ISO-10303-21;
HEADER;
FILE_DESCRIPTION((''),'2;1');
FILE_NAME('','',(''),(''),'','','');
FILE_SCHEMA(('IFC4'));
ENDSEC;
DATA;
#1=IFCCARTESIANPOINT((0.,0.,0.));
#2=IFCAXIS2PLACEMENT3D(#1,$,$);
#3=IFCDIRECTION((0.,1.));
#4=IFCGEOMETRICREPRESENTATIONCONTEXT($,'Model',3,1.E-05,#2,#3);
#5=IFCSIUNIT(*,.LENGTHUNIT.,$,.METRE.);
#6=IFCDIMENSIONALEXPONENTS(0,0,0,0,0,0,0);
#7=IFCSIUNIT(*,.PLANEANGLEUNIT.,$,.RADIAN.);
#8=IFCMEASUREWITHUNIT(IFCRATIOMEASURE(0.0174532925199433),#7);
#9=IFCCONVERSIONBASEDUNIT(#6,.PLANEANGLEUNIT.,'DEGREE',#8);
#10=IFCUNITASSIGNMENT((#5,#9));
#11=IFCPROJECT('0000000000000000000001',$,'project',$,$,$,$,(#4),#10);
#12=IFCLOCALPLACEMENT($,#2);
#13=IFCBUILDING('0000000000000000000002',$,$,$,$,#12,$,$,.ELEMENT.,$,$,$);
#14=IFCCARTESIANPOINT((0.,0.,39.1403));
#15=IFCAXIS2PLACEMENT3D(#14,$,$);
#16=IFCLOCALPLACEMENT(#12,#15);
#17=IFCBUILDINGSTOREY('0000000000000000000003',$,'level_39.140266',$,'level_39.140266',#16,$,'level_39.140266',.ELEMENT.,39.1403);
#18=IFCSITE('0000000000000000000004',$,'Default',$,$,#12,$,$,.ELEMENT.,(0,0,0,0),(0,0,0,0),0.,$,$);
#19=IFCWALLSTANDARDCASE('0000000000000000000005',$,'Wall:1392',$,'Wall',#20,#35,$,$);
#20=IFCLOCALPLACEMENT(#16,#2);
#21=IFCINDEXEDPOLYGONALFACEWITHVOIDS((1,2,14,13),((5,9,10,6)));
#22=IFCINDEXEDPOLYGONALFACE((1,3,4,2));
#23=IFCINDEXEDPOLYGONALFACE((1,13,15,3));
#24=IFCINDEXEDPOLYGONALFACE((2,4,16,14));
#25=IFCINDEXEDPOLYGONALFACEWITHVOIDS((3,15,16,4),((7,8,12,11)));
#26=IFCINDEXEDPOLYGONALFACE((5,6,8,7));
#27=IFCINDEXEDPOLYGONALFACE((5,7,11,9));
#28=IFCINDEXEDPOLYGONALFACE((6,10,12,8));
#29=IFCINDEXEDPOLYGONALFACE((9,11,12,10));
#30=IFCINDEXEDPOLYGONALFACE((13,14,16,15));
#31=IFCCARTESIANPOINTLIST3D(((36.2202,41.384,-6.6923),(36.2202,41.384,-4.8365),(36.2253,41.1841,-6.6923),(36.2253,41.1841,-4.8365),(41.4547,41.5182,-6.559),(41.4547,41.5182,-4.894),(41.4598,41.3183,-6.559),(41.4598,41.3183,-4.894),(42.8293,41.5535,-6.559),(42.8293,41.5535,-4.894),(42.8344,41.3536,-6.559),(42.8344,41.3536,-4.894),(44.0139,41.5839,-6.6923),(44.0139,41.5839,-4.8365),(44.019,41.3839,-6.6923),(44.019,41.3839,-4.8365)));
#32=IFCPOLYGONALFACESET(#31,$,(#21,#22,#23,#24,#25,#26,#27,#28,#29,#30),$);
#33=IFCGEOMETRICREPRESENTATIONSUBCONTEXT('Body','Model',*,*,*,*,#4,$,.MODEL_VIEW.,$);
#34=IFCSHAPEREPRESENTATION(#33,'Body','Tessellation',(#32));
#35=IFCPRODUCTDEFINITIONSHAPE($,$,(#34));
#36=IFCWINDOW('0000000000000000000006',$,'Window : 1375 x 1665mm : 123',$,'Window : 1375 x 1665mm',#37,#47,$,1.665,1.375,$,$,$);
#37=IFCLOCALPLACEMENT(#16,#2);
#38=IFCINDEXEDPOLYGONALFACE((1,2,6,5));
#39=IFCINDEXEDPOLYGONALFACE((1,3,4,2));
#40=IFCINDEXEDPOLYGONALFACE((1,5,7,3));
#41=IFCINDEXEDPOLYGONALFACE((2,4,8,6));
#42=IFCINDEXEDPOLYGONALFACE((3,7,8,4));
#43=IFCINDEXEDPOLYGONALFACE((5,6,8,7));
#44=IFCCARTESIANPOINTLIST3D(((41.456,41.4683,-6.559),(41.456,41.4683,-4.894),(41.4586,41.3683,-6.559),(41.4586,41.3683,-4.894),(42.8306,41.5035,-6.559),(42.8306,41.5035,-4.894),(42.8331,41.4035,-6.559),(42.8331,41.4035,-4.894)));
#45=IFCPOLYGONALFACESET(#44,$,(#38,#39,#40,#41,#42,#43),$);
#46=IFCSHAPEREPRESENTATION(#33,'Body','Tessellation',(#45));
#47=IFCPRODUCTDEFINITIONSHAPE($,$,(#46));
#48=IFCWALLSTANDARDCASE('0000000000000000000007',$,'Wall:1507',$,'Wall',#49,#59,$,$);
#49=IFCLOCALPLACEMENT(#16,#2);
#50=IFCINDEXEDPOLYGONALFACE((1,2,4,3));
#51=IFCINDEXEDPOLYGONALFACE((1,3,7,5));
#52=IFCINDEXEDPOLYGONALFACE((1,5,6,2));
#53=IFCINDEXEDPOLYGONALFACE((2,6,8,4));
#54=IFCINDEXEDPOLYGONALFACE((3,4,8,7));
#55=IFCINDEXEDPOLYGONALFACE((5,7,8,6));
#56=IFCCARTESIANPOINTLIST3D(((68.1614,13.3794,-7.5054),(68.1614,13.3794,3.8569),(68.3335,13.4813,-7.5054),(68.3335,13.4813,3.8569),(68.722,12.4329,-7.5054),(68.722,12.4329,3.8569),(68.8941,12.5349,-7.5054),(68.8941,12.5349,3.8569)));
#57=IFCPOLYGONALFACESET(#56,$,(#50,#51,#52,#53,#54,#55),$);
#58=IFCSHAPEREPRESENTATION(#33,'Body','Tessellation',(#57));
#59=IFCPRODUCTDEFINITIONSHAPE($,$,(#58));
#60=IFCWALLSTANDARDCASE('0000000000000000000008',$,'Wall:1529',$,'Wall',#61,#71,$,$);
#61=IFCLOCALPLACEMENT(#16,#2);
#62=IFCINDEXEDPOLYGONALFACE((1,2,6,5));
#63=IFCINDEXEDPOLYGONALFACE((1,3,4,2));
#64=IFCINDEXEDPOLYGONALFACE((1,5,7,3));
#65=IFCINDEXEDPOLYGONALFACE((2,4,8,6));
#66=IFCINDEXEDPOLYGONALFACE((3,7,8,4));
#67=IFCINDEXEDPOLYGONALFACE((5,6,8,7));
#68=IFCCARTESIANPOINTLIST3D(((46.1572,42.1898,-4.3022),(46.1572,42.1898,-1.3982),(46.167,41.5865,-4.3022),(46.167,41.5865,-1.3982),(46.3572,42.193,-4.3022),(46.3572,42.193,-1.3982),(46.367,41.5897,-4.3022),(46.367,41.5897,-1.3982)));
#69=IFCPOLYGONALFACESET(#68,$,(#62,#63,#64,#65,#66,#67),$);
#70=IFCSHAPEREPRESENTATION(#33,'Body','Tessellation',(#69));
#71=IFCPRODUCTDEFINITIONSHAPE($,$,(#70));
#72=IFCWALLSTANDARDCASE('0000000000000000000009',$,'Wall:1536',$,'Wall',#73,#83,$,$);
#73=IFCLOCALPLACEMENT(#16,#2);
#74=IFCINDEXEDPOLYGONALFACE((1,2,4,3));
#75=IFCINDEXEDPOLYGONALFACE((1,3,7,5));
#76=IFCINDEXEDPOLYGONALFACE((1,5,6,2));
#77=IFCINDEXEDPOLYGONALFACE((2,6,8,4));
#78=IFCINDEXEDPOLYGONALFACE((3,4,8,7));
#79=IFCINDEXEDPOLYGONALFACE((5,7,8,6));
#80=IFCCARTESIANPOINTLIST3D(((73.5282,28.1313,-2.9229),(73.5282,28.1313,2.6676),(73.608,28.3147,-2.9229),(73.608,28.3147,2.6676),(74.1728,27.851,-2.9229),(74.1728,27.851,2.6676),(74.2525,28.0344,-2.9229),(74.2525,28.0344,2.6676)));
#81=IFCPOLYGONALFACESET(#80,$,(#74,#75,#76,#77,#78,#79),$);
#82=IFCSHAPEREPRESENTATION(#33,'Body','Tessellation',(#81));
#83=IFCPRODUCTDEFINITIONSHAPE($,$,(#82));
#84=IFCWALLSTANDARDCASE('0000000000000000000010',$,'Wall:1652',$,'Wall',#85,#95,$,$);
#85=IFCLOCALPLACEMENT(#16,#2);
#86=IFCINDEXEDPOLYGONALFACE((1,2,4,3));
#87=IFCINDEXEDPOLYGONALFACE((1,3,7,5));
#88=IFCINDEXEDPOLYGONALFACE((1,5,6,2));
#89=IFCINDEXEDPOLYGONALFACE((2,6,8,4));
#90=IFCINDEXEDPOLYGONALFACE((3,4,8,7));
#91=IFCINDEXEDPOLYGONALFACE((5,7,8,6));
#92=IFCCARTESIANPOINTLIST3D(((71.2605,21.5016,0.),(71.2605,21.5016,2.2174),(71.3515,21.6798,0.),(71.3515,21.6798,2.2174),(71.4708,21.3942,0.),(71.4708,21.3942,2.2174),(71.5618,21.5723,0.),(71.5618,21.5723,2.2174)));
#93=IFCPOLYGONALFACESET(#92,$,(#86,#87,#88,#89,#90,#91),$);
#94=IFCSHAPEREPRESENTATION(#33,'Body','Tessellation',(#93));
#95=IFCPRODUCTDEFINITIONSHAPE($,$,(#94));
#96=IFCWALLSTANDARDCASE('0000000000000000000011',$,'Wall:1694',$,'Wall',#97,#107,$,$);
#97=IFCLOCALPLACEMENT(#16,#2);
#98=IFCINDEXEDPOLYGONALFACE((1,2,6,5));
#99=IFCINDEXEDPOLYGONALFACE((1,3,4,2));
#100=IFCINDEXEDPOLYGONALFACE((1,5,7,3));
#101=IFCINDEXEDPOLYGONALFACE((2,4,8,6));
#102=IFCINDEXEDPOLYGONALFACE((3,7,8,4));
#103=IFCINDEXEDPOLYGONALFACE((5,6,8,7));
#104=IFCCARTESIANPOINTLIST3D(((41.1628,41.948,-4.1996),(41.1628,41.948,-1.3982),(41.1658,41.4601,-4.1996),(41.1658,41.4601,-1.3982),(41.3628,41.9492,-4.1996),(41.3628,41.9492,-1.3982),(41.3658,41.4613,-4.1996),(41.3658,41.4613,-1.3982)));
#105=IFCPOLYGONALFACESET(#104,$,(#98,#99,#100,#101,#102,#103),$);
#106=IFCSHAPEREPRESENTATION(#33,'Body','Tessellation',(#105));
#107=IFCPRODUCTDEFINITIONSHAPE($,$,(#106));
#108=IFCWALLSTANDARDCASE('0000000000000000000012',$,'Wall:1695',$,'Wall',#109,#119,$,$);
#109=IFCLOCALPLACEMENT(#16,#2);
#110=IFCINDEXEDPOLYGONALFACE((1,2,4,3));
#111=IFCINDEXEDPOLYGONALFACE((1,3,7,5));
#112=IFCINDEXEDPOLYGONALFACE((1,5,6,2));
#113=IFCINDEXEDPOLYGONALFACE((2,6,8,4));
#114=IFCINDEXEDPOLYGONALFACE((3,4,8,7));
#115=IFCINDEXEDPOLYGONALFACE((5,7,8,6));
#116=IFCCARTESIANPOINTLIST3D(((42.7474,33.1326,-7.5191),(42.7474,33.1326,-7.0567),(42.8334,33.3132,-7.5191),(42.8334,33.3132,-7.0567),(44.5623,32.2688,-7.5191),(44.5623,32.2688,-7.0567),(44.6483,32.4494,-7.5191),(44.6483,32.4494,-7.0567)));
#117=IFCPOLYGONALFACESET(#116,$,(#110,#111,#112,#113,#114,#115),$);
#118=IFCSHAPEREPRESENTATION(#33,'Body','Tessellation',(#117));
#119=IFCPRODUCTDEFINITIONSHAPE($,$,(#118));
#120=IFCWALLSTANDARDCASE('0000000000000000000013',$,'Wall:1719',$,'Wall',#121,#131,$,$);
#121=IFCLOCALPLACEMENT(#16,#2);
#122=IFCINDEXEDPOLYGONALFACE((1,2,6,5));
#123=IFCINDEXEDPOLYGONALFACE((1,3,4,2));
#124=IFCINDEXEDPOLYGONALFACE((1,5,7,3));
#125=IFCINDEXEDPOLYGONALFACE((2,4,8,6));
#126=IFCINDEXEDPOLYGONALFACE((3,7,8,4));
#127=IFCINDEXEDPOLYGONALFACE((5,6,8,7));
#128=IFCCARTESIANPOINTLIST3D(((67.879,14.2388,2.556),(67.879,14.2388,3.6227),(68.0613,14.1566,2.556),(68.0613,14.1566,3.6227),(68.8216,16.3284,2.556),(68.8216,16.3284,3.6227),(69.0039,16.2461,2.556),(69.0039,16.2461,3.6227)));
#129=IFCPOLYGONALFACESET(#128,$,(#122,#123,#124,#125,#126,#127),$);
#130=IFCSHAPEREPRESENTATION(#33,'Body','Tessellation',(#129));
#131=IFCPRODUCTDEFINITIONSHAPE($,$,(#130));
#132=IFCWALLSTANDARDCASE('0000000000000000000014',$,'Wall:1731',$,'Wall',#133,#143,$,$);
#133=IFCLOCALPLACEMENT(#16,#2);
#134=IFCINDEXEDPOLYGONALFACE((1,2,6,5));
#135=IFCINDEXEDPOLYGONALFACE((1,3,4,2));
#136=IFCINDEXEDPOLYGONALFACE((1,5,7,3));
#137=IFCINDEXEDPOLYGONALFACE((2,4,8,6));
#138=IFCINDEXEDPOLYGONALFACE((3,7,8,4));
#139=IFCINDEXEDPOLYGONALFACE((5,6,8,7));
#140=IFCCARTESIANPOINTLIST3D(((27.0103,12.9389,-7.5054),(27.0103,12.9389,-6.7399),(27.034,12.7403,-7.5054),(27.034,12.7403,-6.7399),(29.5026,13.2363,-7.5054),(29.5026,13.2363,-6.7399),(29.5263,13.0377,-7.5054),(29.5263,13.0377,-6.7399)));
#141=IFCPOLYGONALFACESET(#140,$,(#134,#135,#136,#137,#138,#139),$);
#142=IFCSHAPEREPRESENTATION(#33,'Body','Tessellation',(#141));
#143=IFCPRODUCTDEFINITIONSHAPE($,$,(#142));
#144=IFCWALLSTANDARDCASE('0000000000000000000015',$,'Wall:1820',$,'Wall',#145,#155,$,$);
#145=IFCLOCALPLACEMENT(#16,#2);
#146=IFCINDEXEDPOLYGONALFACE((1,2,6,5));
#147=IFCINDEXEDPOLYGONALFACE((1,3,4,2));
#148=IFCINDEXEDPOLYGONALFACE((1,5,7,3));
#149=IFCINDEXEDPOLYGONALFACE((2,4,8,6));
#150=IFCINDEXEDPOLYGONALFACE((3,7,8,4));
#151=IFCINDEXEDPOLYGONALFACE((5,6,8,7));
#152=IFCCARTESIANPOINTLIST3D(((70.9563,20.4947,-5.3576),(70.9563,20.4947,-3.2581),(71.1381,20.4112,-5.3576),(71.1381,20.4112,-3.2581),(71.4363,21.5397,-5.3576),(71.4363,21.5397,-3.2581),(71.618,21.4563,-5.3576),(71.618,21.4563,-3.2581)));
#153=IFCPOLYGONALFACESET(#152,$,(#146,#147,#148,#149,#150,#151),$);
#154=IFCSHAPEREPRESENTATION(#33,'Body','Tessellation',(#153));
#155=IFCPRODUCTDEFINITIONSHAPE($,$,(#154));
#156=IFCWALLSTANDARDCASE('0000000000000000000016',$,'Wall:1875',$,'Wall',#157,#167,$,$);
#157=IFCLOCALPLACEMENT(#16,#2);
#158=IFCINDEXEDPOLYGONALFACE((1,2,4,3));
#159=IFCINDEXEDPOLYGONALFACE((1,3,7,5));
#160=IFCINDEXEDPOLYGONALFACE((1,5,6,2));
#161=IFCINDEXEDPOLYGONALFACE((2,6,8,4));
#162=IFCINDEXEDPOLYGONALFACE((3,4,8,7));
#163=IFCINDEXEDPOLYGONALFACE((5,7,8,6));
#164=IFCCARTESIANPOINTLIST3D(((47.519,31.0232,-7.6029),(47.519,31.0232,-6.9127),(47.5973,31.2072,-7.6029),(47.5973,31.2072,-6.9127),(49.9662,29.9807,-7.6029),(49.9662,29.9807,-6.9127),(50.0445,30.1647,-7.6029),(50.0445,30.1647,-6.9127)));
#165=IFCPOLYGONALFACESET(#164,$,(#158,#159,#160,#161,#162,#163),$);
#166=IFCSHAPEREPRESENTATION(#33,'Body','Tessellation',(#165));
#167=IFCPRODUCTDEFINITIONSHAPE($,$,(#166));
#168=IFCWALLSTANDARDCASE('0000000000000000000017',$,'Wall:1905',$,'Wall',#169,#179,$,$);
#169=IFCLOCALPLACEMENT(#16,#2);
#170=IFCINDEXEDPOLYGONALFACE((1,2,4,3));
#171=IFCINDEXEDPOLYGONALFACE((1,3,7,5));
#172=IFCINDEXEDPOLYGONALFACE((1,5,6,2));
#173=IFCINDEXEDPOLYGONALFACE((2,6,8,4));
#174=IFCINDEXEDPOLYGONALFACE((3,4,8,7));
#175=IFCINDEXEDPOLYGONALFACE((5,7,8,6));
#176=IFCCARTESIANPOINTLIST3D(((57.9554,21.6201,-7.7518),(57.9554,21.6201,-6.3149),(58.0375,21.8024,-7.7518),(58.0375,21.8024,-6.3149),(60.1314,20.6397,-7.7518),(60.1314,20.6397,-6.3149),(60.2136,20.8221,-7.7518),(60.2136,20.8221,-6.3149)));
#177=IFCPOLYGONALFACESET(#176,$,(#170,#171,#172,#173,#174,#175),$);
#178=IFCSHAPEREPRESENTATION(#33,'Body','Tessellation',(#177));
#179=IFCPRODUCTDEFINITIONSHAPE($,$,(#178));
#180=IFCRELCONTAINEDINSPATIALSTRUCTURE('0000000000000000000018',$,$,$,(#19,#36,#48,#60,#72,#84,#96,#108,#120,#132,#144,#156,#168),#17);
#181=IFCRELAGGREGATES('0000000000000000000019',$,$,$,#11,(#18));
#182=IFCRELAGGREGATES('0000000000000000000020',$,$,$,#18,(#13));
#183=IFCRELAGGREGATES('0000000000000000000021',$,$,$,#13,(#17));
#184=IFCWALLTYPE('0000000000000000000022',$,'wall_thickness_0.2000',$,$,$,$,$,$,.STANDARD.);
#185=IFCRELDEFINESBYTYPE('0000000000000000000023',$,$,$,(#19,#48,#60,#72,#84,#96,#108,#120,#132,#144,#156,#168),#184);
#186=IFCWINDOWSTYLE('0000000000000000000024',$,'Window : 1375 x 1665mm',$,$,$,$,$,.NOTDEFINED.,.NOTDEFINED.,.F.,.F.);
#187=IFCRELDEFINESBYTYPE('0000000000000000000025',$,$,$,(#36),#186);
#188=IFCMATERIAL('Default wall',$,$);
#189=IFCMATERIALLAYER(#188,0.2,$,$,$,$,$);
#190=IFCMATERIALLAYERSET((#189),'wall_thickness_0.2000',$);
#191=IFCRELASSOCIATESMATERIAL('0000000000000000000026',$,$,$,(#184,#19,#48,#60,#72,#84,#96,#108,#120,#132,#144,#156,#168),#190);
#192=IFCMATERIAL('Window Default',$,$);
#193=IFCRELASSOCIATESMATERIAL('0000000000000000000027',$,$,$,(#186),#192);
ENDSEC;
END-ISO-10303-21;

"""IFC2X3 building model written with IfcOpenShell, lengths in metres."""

from ifc_helpers import new_model, entity, si_unit, converted_unit, direction, frame, frame_2d, origin, origin_2d_with_axis, place, context, subcontext, project, spatial, polyline, rectangle, outline, extrude, source, transform, mapped, material, layer, layer_set, layer_usage, type_object, type_shapes, element, fill, save


model = new_model("IFC2X3")

# Units and contexts
model_context = context("Model", 3, precision=1e-05, world=origin(), true_north=direction((0.0, 1.0)))
body_context = subcontext(model_context, "Body", "Model", "MODEL_VIEW")
ifc_project = project(units=[si_unit("LENGTHUNIT", "METRE"), converted_unit("PLANEANGLEUNIT", "DEGREE", entity("IfcRatioMeasure", 0.0174532925199433), si_unit("PLANEANGLEUNIT", "RADIAN"), dimensions=[0, 0, 0, 0, 0, 0, 0])], contexts=[model_context])

# Site, building, storey
placement_1 = place(None, origin())
site = spatial("IfcSite", under=ifc_project, at=placement_1, Name="Default", CompositionType="ELEMENT", RefLatitude=(0, 0, 0, 0), RefLongitude=(0, 0, 0, 0), RefElevation=0.0)
building = spatial("IfcBuilding", under=site, at=placement_1, CompositionType="ELEMENT")
storey_placement = place(placement_1, frame((0.0, 0.0, 39.1403)))
storey = spatial("IfcBuildingStorey", under=building, at=storey_placement, Name="level_39.140266", ObjectType="level_39.140266", LongName="level_39.140266", CompositionType="ELEMENT", Elevation=39.1403)

# Shared definitions
ifc_material_1 = material(Name="Default wall")
ifc_layer = layer(ifc_material_1, 0.2)
ifc_layer_set = layer_set([ifc_layer], Name="wall_thickness_0.2000")
ifc_layer_usage = layer_usage(ifc_layer_set, "AXIS2", "POSITIVE", -0.1)
wall_type = type_object("IfcWallType", Name="wall_thickness_0.2000", PredefinedType="STANDARD", material=ifc_layer_set)

# Shared definitions
ifc_material_2 = material(Name="Window Default")

# Wall, opening, window
placement_2 = place(placement_1, frame((0.0, 0.0, 32.448)))
wall_1_placement = place(placement_2, frame((36.2227, 41.2841, 0.0), z_axis=(0.0, 0.0, 1.0), x_axis=(0.999671, 0.025631, 0.0)))
wall_1 = element("IfcWallStandardCase", 1, at=wall_1_placement, inside=storey, type_object=wall_type, material=ifc_layer_usage, Name="Wall:1392", ObjectType="Wall", context=body_context, shape_type="SweptSolid", body=[
    extrude(outline(polyline([(7.7963, -0.1), (7.7963, 0.1), (0.0, 0.1), (0.0, -0.1), (7.7963, -0.1)])), origin(), (0.0, 0.0, 1.0), 1.8558),
])
opening_1_placement = place(wall_1_placement, frame((5.2363, -0.1, 0.1333)))
opening_1 = element("IfcOpeningElement", 2, at=opening_1_placement, cuts=wall_1, ObjectType="Opening", context=body_context, shape_type="SweptSolid", body=[
    extrude(rectangle(XDim=1.375, YDim=1.665, at=frame_2d((0.8325, 0.6875), x_axis=(0.0, 1.0))), frame((0.0, 0.0, 0.0), z_axis=(0.0, 1.0, 0.0), x_axis=(0.0, 0.0, 1.0)), (0.0, 0.0, 1.0), 0.2),
])
window_style_1 = type_object("IfcWindowStyle", Name="Window : 1375 x 1665mm", ConstructionType="NOTDEFINED", OperationType="NOTDEFINED", ParameterTakesPrecedence=False, Sizeable=False, material=ifc_material_2)
shared_shape_1 = source(origin(), body_context, "Body", "SweptSolid", [
    extrude(rectangle(XDim=0.1, YDim=1.375, at=origin_2d_with_axis()), frame((0.6875, 0.1, 0.0), z_axis=(0.0, 0.0, 1.0), x_axis=(0.0, 1.0, 0.0)), (0.0, 0.0, 1.0), 1.665),
])
type_shapes(window_style_1, [shared_shape_1])
window_1_placement = place(opening_1_placement, origin())
window_1 = element("IfcWindow", 3, at=window_1_placement, inside=storey, type_object=window_style_1, Name="Window : 1375 x 1665mm : 123", ObjectType="Window : 1375 x 1665mm", OverallHeight=1.665, OverallWidth=1.375, context=body_context, shape_type="MappedRepresentation", body=[
    mapped(shared_shape_1, transform((0.0, 0.0, 0.0), scale=1.0)),
])
fill(opening_1, window_1)

# Walls
placement_3 = place(placement_1, frame((0.0, 0.0, 31.6349)))
wall_2_placement = place(placement_3, frame((68.2474, 13.4303, 0.0), z_axis=(0.0, 0.0, 1.0), x_axis=(0.509623, -0.860398, 0.0)))
element("IfcWallStandardCase", 4, at=wall_2_placement, inside=storey, type_object=wall_type, material=ifc_layer_usage, Name="Wall:1507", ObjectType="Wall", context=body_context, shape_type="SweptSolid", body=[
    extrude(outline(polyline([(1.1, -0.1), (1.1, 0.1), (0.0, 0.1), (0.0, -0.1), (1.1, -0.1)])), origin(), (0.0, 0.0, 1.0), 11.3623),
])
placement_4 = place(placement_1, frame((0.0, 0.0, 34.8381)))
wall_3_placement = place(placement_4, frame((46.2572, 42.1914, 0.0), z_axis=(0.0, 0.0, 1.0), x_axis=(0.016223, -0.999868, 0.0)))
element("IfcWallStandardCase", 5, at=wall_3_placement, inside=storey, type_object=wall_type, material=ifc_layer_usage, Name="Wall:1529", ObjectType="Wall", context=body_context, shape_type="SweptSolid", body=[
    extrude(outline(polyline([(0.6034, -0.1), (0.6034, 0.1), (0.0, 0.1), (0.0, -0.1), (0.6034, -0.1)])), origin(), (0.0, 0.0, 1.0), 2.9041),
])
placement_5 = place(placement_1, frame((0.0, 0.0, 36.2174)))
wall_4_placement = place(placement_5, frame((74.2127, 27.9427, 0.0), z_axis=(0.0, 0.0, 1.0), x_axis=(-0.917026, 0.398828, 0.0)))
element("IfcWallStandardCase", 6, at=wall_4_placement, inside=storey, type_object=wall_type, material=ifc_layer_usage, Name="Wall:1536", ObjectType="Wall", context=body_context, shape_type="SweptSolid", body=[
    extrude(outline(polyline([(0.7029, -0.1), (0.7029, 0.1), (0.0, 0.1), (0.0, -0.1), (0.7029, -0.1)])), origin(), (0.0, 0.0, 1.0), 5.5905),
])
wall_5_placement = place(storey_placement, frame((71.5163, 21.4832, 0.0), z_axis=(0.0, 0.0, 1.0), x_axis=(-0.890541, 0.454903, 0.0)))
element("IfcWallStandardCase", 7, at=wall_5_placement, inside=storey, type_object=wall_type, material=ifc_layer_usage, Name="Wall:1652", ObjectType="Wall", context=body_context, shape_type="SweptSolid", body=[
    extrude(outline(polyline([(0.2362, -0.1), (0.2362, 0.1), (0.0, 0.1), (0.0, -0.1), (0.2362, -0.1)])), origin(), (0.0, 0.0, 1.0), 2.2174),
])
placement_6 = place(placement_1, frame((0.0, 0.0, 34.9407)))
wall_6_placement = place(placement_6, frame((41.2628, 41.9486, 0.0), z_axis=(0.0, 0.0, 1.0), x_axis=(0.006059, -0.999982, 0.0)))
element("IfcWallStandardCase", 8, at=wall_6_placement, inside=storey, type_object=wall_type, material=ifc_layer_usage, Name="Wall:1694", ObjectType="Wall", context=body_context, shape_type="SweptSolid", body=[
    extrude(outline(polyline([(0.4879, -0.1), (0.4879, 0.1), (0.0, 0.1), (0.0, -0.1), (0.4879, -0.1)])), origin(), (0.0, 0.0, 1.0), 2.8015),
])
placement_7 = place(placement_1, frame((0.0, 0.0, 31.6212)))
wall_7_placement = place(placement_7, frame((42.7904, 33.2229, 0.0), z_axis=(0.0, 0.0, 1.0), x_axis=(0.902938, -0.429772, 0.0)))
element("IfcWallStandardCase", 9, at=wall_7_placement, inside=storey, type_object=wall_type, material=ifc_layer_usage, Name="Wall:1695", ObjectType="Wall", context=body_context, shape_type="SweptSolid", body=[
    extrude(outline(polyline([(2.01, -0.1), (2.01, 0.1), (0.0, 0.1), (0.0, -0.1), (2.01, -0.1)])), origin(), (0.0, 0.0, 1.0), 0.4624),
])
placement_8 = place(placement_1, frame((0.0, 0.0, 41.6963)))
wall_8_placement = place(placement_8, frame((67.9701, 14.1977, 0.0), z_axis=(0.0, 0.0, 1.0), x_axis=(0.411224, 0.911534, 0.0)))
element("IfcWallStandardCase", 10, at=wall_8_placement, inside=storey, type_object=wall_type, material=ifc_layer_usage, Name="Wall:1719", ObjectType="Wall", context=body_context, shape_type="SweptSolid", body=[
    extrude(outline(polyline([(2.2923, -0.1), (2.2923, 0.1), (0.0, 0.1), (0.0, -0.1), (2.2923, -0.1)])), origin(), (0.0, 0.0, 1.0), 1.0667),
])
placement_9 = place(placement_1, frame((0.0, 0.0, 31.6349)))
wall_9_placement = place(placement_9, frame((27.0221, 12.8396, 0.0), z_axis=(0.0, 0.0, 1.0), x_axis=(0.992954, 0.118503, 0.0)))
element("IfcWallStandardCase", 11, at=wall_9_placement, inside=storey, type_object=wall_type, material=ifc_layer_usage, Name="Wall:1731", ObjectType="Wall", context=body_context, shape_type="SweptSolid", body=[
    extrude(outline(polyline([(2.51, -0.1), (2.51, 0.1), (0.0, 0.1), (0.0, -0.1), (2.51, -0.1)])), origin(), (0.0, 0.0, 1.0), 0.7655),
])
placement_10 = place(placement_1, frame((0.0, 0.0, 33.7827)))
wall_10_placement = place(placement_10, frame((71.0472, 20.4529, 0.0), z_axis=(0.0, 0.0, 1.0), x_axis=(0.417328, 0.908756, 0.0)))
element("IfcWallStandardCase", 12, at=wall_10_placement, inside=storey, type_object=wall_type, material=ifc_layer_usage, Name="Wall:1820", ObjectType="Wall", context=body_context, shape_type="SweptSolid", body=[
    extrude(outline(polyline([(1.15, -0.1), (1.15, 0.1), (0.0, 0.1), (0.0, -0.1), (1.15, -0.1)])), origin(), (0.0, 0.0, 1.0), 2.0995),
])
placement_11 = place(placement_1, frame((0.0, 0.0, 31.5374)))
wall_11_placement = place(placement_11, frame((47.5581, 31.1152, 0.0), z_axis=(0.0, 0.0, 1.0), x_axis=(0.920002, -0.391914, 0.0)))
element("IfcWallStandardCase", 13, at=wall_11_placement, inside=storey, type_object=wall_type, material=ifc_layer_usage, Name="Wall:1875", ObjectType="Wall", context=body_context, shape_type="SweptSolid", body=[
    extrude(outline(polyline([(2.66, -0.1), (2.66, 0.1), (0.0, 0.1), (0.0, -0.1), (2.66, -0.1)])), origin(), (0.0, 0.0, 1.0), 0.6902),
])
placement_12 = place(placement_1, frame((0.0, 0.0, 31.3885)))
wall_12_placement = place(placement_12, frame((57.9964, 21.7113, 0.0), z_axis=(0.0, 0.0, 1.0), x_axis=(0.911743, -0.410761, 0.0)))
element("IfcWallStandardCase", 14, at=wall_12_placement, inside=storey, type_object=wall_type, material=ifc_layer_usage, Name="Wall:1905", ObjectType="Wall", context=body_context, shape_type="SweptSolid", body=[
    extrude(outline(polyline([(2.3867, -0.1), (2.3867, 0.1), (0.0, 0.1), (0.0, -0.1), (2.3867, -0.1)])), origin(), (0.0, 0.0, 1.0), 1.4369),
])

save(model, "model.ifc")
